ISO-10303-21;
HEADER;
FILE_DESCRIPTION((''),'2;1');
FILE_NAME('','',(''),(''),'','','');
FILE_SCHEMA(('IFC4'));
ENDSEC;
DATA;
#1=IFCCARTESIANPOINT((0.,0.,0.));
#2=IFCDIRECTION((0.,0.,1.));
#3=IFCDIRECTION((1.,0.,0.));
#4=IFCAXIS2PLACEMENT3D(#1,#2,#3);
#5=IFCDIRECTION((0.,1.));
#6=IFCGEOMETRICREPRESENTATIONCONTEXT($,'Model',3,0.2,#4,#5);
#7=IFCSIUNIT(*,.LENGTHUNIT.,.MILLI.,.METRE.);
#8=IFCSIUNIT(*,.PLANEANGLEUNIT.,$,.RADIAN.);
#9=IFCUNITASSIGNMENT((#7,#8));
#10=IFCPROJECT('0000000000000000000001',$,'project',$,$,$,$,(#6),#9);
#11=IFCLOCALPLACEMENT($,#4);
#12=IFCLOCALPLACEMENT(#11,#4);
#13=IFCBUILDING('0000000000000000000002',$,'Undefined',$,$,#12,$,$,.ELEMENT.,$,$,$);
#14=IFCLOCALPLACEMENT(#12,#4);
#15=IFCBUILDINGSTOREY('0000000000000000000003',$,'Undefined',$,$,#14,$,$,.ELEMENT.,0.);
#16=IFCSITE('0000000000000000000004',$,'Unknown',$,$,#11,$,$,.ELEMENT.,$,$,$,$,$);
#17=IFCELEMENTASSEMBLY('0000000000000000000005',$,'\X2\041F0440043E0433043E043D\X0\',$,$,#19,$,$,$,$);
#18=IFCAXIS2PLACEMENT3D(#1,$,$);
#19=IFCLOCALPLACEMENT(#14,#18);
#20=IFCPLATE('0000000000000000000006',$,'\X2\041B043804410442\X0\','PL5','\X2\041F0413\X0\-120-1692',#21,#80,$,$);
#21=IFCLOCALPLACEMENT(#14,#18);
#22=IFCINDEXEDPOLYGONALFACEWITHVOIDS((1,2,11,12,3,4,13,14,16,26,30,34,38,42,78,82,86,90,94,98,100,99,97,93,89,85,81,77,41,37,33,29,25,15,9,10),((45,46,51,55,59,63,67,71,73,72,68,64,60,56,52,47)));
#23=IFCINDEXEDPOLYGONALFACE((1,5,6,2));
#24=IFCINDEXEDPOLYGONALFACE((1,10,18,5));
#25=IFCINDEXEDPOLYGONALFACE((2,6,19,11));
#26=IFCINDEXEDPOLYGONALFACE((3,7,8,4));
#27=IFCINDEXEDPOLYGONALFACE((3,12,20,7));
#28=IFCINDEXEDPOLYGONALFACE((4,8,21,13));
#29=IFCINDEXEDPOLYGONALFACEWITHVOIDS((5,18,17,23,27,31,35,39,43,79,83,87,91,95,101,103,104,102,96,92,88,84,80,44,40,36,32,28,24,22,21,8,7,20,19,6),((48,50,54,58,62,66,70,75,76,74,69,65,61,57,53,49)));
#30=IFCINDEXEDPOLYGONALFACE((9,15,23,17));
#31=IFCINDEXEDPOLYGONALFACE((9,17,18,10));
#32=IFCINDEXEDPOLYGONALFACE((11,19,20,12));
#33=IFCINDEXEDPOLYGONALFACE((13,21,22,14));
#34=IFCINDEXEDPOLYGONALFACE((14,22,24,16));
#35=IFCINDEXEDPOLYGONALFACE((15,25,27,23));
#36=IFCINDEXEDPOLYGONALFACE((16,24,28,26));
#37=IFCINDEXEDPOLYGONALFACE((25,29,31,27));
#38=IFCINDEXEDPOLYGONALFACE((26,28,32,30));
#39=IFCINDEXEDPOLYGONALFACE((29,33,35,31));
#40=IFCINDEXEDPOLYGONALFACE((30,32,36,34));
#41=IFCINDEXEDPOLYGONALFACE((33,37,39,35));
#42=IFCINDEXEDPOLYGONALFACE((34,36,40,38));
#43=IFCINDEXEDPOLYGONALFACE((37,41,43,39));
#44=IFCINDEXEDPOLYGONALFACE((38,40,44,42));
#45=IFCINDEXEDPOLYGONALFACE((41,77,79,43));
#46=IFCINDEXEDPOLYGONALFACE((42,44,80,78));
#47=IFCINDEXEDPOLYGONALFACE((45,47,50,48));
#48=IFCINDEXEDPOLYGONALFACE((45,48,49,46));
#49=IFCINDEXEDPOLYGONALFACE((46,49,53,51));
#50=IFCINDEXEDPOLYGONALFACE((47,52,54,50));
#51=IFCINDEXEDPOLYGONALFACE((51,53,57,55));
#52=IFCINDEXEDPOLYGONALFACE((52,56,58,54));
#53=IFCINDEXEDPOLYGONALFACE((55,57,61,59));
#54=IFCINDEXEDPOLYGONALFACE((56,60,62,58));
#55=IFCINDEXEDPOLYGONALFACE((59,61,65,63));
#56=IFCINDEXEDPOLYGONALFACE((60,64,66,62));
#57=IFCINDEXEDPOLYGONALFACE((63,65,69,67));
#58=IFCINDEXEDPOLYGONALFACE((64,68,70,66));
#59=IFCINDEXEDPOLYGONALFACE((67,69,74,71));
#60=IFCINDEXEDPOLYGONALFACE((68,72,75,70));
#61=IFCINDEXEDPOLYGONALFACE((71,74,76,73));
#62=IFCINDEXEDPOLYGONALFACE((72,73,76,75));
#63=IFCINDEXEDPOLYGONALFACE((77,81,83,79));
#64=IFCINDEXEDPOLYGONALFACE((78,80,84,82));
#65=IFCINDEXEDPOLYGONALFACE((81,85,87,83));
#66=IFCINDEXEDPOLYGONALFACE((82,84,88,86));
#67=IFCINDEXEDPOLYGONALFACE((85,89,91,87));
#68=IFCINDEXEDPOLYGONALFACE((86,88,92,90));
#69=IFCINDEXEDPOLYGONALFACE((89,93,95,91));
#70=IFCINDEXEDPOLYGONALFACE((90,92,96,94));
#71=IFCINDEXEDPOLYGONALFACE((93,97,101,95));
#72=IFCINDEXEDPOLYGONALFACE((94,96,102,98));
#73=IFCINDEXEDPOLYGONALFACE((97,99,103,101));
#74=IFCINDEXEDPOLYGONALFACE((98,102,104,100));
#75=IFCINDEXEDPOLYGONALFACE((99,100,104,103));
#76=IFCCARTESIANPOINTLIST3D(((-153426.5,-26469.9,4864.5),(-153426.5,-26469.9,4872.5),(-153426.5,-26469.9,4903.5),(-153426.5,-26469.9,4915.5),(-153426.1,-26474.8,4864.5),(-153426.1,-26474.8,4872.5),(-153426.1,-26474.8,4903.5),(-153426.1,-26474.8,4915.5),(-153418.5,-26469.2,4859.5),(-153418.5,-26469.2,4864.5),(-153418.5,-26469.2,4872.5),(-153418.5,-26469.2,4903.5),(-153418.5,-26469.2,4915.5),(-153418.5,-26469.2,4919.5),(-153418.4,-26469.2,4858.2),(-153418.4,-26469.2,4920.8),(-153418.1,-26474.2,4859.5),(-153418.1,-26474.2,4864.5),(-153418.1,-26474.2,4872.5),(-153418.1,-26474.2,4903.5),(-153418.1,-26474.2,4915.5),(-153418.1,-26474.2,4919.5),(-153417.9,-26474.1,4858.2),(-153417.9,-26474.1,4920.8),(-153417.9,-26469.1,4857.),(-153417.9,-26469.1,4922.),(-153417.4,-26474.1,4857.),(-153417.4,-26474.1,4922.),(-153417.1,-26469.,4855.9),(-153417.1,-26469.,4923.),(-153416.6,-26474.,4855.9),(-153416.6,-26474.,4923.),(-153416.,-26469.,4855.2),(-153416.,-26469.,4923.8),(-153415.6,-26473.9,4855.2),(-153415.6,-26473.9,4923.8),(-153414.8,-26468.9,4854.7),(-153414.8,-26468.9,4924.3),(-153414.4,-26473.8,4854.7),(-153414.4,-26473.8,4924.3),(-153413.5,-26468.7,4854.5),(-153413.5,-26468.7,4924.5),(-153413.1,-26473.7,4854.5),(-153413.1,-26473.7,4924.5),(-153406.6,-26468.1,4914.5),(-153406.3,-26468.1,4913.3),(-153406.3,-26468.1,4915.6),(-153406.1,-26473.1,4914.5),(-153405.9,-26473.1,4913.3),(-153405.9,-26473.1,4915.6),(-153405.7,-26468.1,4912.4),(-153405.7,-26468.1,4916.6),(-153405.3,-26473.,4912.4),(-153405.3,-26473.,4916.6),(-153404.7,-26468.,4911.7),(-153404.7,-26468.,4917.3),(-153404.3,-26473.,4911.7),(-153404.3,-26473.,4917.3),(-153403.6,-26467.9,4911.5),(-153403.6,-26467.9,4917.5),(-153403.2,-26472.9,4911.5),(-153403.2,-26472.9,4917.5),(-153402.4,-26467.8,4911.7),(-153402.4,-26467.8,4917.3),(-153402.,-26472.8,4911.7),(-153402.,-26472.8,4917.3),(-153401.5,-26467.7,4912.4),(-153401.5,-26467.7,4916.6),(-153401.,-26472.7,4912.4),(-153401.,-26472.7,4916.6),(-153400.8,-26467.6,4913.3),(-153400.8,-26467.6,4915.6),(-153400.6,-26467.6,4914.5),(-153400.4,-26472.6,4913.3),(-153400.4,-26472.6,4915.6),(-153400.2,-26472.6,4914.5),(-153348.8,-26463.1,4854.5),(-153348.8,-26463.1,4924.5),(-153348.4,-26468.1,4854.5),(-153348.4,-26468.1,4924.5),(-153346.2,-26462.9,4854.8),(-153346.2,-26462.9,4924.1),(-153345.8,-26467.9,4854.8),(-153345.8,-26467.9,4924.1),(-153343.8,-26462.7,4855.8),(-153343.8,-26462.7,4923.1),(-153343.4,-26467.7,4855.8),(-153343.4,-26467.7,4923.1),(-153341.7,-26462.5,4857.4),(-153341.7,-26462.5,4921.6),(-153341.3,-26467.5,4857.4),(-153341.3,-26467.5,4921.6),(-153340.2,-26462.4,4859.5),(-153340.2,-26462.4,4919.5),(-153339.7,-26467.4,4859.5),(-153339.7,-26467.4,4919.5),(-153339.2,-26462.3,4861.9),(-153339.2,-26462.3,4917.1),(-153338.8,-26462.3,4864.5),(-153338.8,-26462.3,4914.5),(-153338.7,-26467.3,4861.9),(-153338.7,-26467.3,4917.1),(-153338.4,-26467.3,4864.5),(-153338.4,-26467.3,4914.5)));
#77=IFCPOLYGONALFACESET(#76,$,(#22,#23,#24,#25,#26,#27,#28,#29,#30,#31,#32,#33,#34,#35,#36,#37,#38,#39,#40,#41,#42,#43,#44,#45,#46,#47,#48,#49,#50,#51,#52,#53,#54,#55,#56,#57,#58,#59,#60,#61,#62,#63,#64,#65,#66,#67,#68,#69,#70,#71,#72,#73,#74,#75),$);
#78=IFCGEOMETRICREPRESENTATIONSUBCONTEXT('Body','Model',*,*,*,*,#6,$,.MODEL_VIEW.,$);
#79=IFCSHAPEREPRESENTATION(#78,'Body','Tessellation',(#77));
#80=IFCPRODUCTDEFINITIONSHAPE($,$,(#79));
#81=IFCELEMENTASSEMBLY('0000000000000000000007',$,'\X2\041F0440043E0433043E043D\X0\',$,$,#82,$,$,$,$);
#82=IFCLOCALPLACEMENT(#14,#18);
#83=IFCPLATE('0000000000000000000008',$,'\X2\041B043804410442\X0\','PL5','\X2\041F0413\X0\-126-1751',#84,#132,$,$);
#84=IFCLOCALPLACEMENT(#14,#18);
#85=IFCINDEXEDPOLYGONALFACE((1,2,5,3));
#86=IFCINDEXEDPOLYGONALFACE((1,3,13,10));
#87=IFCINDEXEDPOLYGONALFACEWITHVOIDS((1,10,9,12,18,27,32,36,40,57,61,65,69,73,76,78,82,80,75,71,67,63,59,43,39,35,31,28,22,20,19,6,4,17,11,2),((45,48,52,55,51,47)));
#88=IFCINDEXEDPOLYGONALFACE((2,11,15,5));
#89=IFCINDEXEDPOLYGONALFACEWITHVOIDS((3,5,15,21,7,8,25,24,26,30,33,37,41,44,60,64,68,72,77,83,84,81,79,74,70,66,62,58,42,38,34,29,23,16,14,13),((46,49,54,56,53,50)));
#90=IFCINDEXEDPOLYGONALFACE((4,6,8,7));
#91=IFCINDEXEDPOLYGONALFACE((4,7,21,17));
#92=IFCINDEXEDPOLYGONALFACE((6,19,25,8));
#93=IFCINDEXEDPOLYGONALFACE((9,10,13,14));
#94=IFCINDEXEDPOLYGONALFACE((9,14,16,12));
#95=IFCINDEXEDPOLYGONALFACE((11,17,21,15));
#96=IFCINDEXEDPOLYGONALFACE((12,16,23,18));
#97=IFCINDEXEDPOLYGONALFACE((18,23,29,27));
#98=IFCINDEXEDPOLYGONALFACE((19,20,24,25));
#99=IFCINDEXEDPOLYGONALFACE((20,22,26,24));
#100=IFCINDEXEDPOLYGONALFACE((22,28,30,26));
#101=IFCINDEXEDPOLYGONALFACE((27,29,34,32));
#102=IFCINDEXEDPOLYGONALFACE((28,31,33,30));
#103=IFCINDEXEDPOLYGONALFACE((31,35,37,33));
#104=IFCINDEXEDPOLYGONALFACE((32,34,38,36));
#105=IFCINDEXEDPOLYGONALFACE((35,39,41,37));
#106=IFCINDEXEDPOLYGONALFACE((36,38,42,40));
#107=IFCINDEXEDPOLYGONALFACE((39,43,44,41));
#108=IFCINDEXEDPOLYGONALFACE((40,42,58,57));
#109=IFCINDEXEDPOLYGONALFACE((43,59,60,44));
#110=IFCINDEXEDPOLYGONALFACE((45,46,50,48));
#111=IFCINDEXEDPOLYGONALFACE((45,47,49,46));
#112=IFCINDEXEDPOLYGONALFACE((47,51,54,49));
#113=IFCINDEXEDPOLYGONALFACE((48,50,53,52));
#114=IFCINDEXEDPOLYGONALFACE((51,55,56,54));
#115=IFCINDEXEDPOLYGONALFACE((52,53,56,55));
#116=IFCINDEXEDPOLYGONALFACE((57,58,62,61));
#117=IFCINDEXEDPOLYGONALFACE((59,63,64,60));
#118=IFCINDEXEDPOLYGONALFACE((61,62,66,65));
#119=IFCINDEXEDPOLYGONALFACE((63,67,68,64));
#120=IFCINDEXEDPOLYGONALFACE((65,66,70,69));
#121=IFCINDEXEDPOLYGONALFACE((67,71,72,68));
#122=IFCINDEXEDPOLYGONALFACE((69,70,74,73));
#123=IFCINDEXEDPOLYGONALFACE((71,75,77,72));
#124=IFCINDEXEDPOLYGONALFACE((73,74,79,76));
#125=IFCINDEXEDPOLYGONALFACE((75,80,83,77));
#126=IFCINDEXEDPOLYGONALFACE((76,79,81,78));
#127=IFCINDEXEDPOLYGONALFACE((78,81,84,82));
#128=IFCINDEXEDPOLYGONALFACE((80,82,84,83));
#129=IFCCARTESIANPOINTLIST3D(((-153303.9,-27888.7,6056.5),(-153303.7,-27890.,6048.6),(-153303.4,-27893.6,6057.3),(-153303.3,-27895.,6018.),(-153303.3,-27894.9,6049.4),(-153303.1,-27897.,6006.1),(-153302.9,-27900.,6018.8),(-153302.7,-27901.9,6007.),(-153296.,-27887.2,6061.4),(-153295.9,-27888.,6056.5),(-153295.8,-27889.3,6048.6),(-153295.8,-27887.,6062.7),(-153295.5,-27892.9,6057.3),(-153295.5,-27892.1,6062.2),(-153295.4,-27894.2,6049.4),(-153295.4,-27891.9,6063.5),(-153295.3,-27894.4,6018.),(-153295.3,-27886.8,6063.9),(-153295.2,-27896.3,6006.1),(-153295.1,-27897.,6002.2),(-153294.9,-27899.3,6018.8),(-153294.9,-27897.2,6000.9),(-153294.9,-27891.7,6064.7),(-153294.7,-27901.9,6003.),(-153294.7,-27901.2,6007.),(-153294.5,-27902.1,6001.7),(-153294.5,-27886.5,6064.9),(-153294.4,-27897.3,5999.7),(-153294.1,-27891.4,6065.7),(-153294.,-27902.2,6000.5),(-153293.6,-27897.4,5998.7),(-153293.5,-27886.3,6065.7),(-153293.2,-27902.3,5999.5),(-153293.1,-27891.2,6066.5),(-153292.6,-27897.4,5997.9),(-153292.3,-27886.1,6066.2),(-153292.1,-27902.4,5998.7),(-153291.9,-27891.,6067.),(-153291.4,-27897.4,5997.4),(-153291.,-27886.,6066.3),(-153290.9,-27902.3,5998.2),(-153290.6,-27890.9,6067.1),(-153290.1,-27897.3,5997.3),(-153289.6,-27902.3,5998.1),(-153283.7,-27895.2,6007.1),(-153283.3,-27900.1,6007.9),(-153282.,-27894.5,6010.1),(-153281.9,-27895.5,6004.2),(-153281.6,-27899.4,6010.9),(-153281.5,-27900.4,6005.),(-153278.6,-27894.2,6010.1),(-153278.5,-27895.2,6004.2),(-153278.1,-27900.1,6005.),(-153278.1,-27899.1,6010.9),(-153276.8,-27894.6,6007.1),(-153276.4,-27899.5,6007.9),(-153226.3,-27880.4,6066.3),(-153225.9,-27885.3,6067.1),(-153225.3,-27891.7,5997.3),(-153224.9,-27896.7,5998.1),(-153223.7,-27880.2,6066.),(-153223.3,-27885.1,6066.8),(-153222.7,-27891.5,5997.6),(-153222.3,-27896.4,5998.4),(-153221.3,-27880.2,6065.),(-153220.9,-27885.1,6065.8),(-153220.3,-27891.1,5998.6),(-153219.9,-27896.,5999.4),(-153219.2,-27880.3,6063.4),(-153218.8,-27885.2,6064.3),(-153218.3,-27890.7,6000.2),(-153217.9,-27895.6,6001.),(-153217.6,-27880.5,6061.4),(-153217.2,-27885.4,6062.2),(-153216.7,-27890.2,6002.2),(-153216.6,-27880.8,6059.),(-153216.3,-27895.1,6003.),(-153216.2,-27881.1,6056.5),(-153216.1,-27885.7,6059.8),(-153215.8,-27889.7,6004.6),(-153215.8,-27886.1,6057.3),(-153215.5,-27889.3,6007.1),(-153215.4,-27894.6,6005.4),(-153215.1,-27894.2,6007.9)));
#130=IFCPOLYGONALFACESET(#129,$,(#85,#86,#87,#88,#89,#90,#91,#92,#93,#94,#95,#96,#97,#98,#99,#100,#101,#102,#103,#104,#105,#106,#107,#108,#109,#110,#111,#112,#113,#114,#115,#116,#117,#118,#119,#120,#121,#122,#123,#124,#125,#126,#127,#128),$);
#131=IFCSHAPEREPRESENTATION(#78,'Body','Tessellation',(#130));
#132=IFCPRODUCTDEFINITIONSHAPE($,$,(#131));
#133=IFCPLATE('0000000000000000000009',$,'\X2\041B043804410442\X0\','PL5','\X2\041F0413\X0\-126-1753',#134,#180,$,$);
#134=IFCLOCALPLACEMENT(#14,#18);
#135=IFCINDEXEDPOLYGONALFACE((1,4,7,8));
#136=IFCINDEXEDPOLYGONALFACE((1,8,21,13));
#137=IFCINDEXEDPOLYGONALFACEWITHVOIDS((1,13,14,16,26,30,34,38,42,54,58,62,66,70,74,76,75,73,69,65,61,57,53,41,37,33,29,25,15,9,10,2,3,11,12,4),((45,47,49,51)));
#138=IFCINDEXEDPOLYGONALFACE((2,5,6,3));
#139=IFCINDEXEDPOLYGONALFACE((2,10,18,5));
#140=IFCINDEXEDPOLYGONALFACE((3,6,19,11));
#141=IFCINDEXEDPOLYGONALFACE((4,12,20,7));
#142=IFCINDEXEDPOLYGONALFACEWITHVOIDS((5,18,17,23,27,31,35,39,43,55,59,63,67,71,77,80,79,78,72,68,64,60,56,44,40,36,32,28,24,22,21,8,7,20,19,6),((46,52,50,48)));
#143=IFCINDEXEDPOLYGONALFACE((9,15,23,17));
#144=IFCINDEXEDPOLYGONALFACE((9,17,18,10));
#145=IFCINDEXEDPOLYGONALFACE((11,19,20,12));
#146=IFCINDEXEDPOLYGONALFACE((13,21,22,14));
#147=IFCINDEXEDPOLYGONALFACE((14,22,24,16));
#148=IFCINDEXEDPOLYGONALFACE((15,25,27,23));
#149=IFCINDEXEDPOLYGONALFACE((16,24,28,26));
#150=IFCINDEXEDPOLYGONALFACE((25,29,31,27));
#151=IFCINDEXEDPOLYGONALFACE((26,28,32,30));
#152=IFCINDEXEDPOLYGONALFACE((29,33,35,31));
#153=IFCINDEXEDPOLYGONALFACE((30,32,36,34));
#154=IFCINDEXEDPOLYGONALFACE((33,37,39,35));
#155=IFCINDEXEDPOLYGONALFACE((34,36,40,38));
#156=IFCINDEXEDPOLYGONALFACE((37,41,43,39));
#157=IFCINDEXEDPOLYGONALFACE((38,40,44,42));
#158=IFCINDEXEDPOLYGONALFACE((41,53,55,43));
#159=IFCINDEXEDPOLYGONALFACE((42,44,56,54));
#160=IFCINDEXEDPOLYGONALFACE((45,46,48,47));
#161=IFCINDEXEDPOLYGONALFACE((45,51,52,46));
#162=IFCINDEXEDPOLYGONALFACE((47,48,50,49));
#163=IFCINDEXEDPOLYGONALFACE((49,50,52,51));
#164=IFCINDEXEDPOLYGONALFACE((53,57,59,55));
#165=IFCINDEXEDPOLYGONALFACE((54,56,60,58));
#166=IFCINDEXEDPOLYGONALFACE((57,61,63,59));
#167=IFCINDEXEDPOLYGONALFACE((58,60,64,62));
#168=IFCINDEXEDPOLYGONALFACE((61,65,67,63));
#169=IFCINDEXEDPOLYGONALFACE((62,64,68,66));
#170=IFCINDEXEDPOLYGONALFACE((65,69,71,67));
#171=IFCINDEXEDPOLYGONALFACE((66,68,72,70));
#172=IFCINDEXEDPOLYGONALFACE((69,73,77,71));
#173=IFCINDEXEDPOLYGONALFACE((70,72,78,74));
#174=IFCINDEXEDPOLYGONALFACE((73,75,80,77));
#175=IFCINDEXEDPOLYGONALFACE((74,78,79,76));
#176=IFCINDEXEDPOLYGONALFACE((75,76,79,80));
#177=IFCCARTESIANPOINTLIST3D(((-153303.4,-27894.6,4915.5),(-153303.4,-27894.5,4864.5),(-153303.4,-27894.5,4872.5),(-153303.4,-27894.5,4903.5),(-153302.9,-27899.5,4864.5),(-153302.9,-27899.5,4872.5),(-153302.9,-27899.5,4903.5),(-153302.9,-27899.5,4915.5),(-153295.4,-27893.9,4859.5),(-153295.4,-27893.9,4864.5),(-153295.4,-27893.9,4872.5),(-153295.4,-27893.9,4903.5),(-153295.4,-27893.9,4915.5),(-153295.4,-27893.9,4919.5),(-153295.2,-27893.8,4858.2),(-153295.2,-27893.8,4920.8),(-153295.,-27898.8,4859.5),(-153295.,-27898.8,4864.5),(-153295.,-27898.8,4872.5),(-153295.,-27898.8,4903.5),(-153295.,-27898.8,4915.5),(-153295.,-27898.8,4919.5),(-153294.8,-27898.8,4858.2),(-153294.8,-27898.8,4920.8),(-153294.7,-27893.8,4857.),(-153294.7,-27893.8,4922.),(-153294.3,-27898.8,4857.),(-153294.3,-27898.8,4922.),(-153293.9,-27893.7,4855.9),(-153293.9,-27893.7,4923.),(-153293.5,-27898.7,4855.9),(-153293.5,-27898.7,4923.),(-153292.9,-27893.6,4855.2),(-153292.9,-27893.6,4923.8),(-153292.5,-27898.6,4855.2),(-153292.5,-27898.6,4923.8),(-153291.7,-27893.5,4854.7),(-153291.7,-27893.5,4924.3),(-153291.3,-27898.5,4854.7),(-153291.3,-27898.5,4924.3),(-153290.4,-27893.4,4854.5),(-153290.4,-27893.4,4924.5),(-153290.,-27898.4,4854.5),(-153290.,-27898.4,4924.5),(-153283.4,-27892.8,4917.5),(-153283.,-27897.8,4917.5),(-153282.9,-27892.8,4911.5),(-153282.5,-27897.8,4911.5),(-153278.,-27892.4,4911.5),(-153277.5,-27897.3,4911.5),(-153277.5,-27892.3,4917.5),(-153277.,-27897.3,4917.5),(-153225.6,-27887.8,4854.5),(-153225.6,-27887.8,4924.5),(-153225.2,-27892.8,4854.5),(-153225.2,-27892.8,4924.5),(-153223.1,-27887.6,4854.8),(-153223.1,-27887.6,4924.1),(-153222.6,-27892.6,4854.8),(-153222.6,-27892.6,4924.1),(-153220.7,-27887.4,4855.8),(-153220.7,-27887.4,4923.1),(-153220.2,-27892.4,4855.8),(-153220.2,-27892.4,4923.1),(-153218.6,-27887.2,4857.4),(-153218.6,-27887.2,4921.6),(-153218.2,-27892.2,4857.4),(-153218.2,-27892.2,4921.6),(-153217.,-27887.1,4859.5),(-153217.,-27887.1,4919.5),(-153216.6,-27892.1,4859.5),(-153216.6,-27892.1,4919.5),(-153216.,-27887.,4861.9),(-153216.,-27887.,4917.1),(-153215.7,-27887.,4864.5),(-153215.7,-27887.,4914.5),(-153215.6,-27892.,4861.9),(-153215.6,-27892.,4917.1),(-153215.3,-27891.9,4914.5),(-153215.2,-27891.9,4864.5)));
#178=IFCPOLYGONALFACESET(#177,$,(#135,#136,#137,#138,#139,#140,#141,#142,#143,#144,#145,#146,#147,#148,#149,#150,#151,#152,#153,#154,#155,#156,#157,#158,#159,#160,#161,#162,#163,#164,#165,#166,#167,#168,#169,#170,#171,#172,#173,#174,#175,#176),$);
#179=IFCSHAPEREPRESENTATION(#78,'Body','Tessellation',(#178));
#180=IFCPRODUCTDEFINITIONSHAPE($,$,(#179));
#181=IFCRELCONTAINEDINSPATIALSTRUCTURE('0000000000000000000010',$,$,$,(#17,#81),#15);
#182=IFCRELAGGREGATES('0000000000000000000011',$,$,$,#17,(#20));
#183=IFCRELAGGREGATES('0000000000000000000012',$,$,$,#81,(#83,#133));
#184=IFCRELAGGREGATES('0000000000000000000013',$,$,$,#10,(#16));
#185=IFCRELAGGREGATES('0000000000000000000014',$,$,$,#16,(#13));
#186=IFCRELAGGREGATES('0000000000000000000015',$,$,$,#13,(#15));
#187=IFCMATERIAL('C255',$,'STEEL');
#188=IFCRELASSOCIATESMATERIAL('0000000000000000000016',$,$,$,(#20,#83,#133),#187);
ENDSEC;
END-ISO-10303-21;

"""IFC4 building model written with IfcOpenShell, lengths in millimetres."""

from ifc_helpers import new_model, si_unit, direction, frame, origin_with_axes, place, context, subcontext, project, spatial, line, arc, indexed_curve, outline, extrude, material, element, aggregate, save


model = new_model("IFC4")

# Units and contexts
model_context = context("Model", 3, precision=0.2, world=origin_with_axes(), true_north=direction((0.0, 1.0)))
body_context = subcontext(model_context, "Body", "Model", "MODEL_VIEW")
ifc_project = project(units=[si_unit("LENGTHUNIT", "METRE", prefix="MILLI"), si_unit("PLANEANGLEUNIT", "RADIAN")], contexts=[model_context])

# Site, building, storey
site_placement = place(None, origin_with_axes())
site = spatial("IfcSite", under=ifc_project, at=site_placement, Name="Unknown", CompositionType="ELEMENT")
building_placement = place(site_placement, origin_with_axes())
building = spatial("IfcBuilding", under=site, at=building_placement, Name="Undefined", CompositionType="ELEMENT")
storey_placement = place(building_placement, origin_with_axes())
storey = spatial("IfcBuildingStorey", under=building, at=storey_placement, Name="Undefined", CompositionType="ELEMENT", Elevation=0.0)

# Shared definitions
ifc_material_1 = material(Name="C255", Category="STEEL")

# Element assemblies, plates, voiding features
assembly_1_placement = place(storey_placement, frame((-153458.2, -26475.1, 4779.5), z_axis=(0.086114, -0.996285, 0.0), x_axis=(0.0, 0.0, 1.0)))
assembly_1 = element("IfcElementAssembly", 1, at=assembly_1_placement, inside=storey, Name="Прогон")
plate_1_placement = place(assembly_1_placement, frame((75.0, -120.0, 0.0), z_axis=(0.0, -0.000057, 1.0), x_axis=(1.0, 0.000078, 0.0)))
plate_1 = element("IfcPlate", 2, at=plate_1_placement, material=ifc_material_1, Name="Лист", Description="PL5", ObjectType="ПГ-120-1692", context=body_context, shape_type="SolidModel", body=[
    extrude(outline(indexed_curve([(0.0, 10.0), (2.9, 2.9), (10.0, 0.0), (60.0, 0.0), (67.1, 2.9), (70.0, 10.0), (70.0, 75.0), (68.5, 78.5), (65.0, 80.0), (61.0, 80.0), (61.0, 88.0), (49.0, 88.0), (49.0, 80.0), (18.0, 80.0), (18.0, 88.0), (10.0, 88.0), (10.0, 80.0), (5.0, 80.0), (1.5, 78.5), (0.0, 75.0)], segments=[arc(1, 2, 3), line(3, 4), arc(4, 5, 6), line(6, 7), arc(7, 8, 9), line(9, 10, 11, 12, 13, 14, 15, 16, 17, 18), arc(18, 19, 20), line(20, 1)])), frame((0.0, 0.0, 2.5), z_axis=(0.0, 0.0, 1.0), x_axis=(1.0, 0.0, 0.0)), (0.0, 0.0, -1.0), 5.0),
])
voiding_feature_1_placement = place(plate_1_placement, frame((60.0, 65.0, 6.0), z_axis=(-0.000054, -1.0, 0.000034), x_axis=(0.0, -0.000034, -1.0)))
element("IfcVoidingFeature", 3, at=voiding_feature_1_placement, cuts=plate_1, Name="Балка", ObjectType="(?)", PredefinedType="HOLE", context=body_context, shape_type="SolidModel", body=[
    extrude(outline(indexed_curve([(3.0, 0.0), (2.8, 1.1), (2.1, 2.1), (1.1, 2.8), (0.0, 3.0), (-1.1, 2.8), (-2.1, 2.1), (-2.8, 1.1), (-3.0, 0.0), (-2.8, -1.1), (-2.1, -2.1), (-1.1, -2.8), (0.0, -3.0), (1.1, -2.8), (2.1, -2.1), (2.8, -1.1)], segments=[line(1, 2, 3, 4, 5, 6, 7, 8, 9, 10, 11, 12, 13, 14, 15, 16, 1)])), frame((0.0, 0.0, 0.0), z_axis=(-1.0, 0.0, 0.0), x_axis=(0.0, 0.0, 1.0)), (0.0, 0.0, -1.0), 12.0),
])
assembly_2_placement = place(storey_placement, frame((-153335.0, -27899.8, 4629.5), z_axis=(0.086114, -0.996285, 0.0), x_axis=(0.0, 0.0, 1.0)))
assembly_2 = element("IfcElementAssembly", 4, at=assembly_2_placement, inside=storey, Name="Прогон")
plate_2_placement = place(assembly_2_placement, frame((1437.2, -120.0, -7.5), z_axis=(-0.162881, -0.000054, -0.986646), x_axis=(-0.986646, 0.000078, 0.162881)))
plate_2 = element("IfcPlate", 5, at=plate_2_placement, material=ifc_material_1, Name="Лист", Description="PL5", ObjectType="ПГ-126-1751", context=body_context, shape_type="SolidModel", body=[
    extrude(outline(indexed_curve([(0.0, 10.0), (2.9, 2.9), (10.0, 0.0), (60.0, 0.0), (67.1, 2.9), (70.0, 10.0), (70.0, 75.0), (68.5, 78.5), (65.0, 80.0), (61.0, 80.0), (61.0, 88.0), (49.0, 88.0), (49.0, 80.0), (18.0, 80.0), (18.0, 88.0), (10.0, 88.0), (10.0, 80.0), (5.0, 80.0), (1.5, 78.5), (0.0, 75.0)], segments=[arc(1, 2, 3), line(3, 4), arc(4, 5, 6), line(6, 7), arc(7, 8, 9), line(9, 10, 11, 12, 13, 14, 15, 16, 17, 18), arc(18, 19, 20), line(20, 1)])), frame((0.0, 0.0, 2.5), z_axis=(0.0, 0.0, 1.0), x_axis=(1.0, 0.0, 0.0)), (0.0, 0.0, -1.0), 5.0),
])
voiding_feature_2_placement = place(plate_2_placement, frame((60.0, 65.0, 6.0), z_axis=(-0.000054, -1.0, 0.000034), x_axis=(0.0, -0.000034, -1.0)))
element("IfcVoidingFeature", 6, at=voiding_feature_2_placement, cuts=plate_2, Name="Балка", ObjectType="(?)", PredefinedType="HOLE", context=body_context, shape_type="SolidModel", body=[
    extrude(outline(indexed_curve([(1.7, -3.0), (3.5, 0.0), (1.7, 3.0), (-1.7, 3.0), (-3.5, 0.0), (-1.7, -3.0)], segments=[line(1, 2, 3, 4, 5, 6, 1)])), frame((0.0, 0.0, 0.0), z_axis=(-1.0, 0.0, 0.0), x_axis=(0.0, 0.0, 1.0)), (0.0, 0.0, -1.0), 12.0),
])
plate_3_placement = place(assembly_2_placement, frame((225.0, -120.0, 0.0), z_axis=(0.0, -0.000057, 1.0), x_axis=(1.0, 0.000078, 0.0)))
plate_3 = element("IfcPlate", 7, at=plate_3_placement, material=ifc_material_1, Name="Лист", Description="PL5", ObjectType="ПГ-126-1753", context=body_context, shape_type="SolidModel", body=[
    extrude(outline(indexed_curve([(0.0, 10.0), (2.9, 2.9), (10.0, 0.0), (60.0, 0.0), (67.1, 2.9), (70.0, 10.0), (70.0, 75.0), (68.5, 78.5), (65.0, 80.0), (61.0, 80.0), (61.0, 88.0), (49.0, 88.0), (49.0, 80.0), (18.0, 80.0), (18.0, 88.0), (10.0, 88.0), (10.0, 80.0), (5.0, 80.0), (1.5, 78.5), (0.0, 75.0)], segments=[arc(1, 2, 3), line(3, 4), arc(4, 5, 6), line(6, 7), arc(7, 8, 9), line(9, 10, 11, 12, 13, 14, 15, 16, 17, 18), arc(18, 19, 20), line(20, 1)])), frame((0.0, 0.0, 2.5), z_axis=(0.0, 0.0, 1.0), x_axis=(1.0, 0.0, 0.0)), (0.0, 0.0, -1.0), 5.0),
])
voiding_feature_3_placement = place(plate_3_placement, frame((60.0, 65.0, 6.0), z_axis=(-0.000054, -1.0, 0.000034), x_axis=(0.0, -0.000034, -1.0)))
element("IfcVoidingFeature", 8, at=voiding_feature_3_placement, cuts=plate_3, Name="Балка", ObjectType="(?)", PredefinedType="HOLE", context=body_context, shape_type="SolidModel", body=[
    extrude(outline(indexed_curve([(2.5, -3.0), (3.0, 3.0), (-3.0, 3.0), (-2.5, -3.0)], segments=[line(1, 2, 3, 4, 1)])), frame((0.0, 0.0, 0.0), z_axis=(-1.0, 0.0, 0.0), x_axis=(0.0, 0.0, 1.0)), (0.0, 0.0, -1.0), 12.0),
])

aggregate(assembly_1, [plate_1])
aggregate(assembly_2, [plate_2, plate_3])

save(model, "model.ifc")
